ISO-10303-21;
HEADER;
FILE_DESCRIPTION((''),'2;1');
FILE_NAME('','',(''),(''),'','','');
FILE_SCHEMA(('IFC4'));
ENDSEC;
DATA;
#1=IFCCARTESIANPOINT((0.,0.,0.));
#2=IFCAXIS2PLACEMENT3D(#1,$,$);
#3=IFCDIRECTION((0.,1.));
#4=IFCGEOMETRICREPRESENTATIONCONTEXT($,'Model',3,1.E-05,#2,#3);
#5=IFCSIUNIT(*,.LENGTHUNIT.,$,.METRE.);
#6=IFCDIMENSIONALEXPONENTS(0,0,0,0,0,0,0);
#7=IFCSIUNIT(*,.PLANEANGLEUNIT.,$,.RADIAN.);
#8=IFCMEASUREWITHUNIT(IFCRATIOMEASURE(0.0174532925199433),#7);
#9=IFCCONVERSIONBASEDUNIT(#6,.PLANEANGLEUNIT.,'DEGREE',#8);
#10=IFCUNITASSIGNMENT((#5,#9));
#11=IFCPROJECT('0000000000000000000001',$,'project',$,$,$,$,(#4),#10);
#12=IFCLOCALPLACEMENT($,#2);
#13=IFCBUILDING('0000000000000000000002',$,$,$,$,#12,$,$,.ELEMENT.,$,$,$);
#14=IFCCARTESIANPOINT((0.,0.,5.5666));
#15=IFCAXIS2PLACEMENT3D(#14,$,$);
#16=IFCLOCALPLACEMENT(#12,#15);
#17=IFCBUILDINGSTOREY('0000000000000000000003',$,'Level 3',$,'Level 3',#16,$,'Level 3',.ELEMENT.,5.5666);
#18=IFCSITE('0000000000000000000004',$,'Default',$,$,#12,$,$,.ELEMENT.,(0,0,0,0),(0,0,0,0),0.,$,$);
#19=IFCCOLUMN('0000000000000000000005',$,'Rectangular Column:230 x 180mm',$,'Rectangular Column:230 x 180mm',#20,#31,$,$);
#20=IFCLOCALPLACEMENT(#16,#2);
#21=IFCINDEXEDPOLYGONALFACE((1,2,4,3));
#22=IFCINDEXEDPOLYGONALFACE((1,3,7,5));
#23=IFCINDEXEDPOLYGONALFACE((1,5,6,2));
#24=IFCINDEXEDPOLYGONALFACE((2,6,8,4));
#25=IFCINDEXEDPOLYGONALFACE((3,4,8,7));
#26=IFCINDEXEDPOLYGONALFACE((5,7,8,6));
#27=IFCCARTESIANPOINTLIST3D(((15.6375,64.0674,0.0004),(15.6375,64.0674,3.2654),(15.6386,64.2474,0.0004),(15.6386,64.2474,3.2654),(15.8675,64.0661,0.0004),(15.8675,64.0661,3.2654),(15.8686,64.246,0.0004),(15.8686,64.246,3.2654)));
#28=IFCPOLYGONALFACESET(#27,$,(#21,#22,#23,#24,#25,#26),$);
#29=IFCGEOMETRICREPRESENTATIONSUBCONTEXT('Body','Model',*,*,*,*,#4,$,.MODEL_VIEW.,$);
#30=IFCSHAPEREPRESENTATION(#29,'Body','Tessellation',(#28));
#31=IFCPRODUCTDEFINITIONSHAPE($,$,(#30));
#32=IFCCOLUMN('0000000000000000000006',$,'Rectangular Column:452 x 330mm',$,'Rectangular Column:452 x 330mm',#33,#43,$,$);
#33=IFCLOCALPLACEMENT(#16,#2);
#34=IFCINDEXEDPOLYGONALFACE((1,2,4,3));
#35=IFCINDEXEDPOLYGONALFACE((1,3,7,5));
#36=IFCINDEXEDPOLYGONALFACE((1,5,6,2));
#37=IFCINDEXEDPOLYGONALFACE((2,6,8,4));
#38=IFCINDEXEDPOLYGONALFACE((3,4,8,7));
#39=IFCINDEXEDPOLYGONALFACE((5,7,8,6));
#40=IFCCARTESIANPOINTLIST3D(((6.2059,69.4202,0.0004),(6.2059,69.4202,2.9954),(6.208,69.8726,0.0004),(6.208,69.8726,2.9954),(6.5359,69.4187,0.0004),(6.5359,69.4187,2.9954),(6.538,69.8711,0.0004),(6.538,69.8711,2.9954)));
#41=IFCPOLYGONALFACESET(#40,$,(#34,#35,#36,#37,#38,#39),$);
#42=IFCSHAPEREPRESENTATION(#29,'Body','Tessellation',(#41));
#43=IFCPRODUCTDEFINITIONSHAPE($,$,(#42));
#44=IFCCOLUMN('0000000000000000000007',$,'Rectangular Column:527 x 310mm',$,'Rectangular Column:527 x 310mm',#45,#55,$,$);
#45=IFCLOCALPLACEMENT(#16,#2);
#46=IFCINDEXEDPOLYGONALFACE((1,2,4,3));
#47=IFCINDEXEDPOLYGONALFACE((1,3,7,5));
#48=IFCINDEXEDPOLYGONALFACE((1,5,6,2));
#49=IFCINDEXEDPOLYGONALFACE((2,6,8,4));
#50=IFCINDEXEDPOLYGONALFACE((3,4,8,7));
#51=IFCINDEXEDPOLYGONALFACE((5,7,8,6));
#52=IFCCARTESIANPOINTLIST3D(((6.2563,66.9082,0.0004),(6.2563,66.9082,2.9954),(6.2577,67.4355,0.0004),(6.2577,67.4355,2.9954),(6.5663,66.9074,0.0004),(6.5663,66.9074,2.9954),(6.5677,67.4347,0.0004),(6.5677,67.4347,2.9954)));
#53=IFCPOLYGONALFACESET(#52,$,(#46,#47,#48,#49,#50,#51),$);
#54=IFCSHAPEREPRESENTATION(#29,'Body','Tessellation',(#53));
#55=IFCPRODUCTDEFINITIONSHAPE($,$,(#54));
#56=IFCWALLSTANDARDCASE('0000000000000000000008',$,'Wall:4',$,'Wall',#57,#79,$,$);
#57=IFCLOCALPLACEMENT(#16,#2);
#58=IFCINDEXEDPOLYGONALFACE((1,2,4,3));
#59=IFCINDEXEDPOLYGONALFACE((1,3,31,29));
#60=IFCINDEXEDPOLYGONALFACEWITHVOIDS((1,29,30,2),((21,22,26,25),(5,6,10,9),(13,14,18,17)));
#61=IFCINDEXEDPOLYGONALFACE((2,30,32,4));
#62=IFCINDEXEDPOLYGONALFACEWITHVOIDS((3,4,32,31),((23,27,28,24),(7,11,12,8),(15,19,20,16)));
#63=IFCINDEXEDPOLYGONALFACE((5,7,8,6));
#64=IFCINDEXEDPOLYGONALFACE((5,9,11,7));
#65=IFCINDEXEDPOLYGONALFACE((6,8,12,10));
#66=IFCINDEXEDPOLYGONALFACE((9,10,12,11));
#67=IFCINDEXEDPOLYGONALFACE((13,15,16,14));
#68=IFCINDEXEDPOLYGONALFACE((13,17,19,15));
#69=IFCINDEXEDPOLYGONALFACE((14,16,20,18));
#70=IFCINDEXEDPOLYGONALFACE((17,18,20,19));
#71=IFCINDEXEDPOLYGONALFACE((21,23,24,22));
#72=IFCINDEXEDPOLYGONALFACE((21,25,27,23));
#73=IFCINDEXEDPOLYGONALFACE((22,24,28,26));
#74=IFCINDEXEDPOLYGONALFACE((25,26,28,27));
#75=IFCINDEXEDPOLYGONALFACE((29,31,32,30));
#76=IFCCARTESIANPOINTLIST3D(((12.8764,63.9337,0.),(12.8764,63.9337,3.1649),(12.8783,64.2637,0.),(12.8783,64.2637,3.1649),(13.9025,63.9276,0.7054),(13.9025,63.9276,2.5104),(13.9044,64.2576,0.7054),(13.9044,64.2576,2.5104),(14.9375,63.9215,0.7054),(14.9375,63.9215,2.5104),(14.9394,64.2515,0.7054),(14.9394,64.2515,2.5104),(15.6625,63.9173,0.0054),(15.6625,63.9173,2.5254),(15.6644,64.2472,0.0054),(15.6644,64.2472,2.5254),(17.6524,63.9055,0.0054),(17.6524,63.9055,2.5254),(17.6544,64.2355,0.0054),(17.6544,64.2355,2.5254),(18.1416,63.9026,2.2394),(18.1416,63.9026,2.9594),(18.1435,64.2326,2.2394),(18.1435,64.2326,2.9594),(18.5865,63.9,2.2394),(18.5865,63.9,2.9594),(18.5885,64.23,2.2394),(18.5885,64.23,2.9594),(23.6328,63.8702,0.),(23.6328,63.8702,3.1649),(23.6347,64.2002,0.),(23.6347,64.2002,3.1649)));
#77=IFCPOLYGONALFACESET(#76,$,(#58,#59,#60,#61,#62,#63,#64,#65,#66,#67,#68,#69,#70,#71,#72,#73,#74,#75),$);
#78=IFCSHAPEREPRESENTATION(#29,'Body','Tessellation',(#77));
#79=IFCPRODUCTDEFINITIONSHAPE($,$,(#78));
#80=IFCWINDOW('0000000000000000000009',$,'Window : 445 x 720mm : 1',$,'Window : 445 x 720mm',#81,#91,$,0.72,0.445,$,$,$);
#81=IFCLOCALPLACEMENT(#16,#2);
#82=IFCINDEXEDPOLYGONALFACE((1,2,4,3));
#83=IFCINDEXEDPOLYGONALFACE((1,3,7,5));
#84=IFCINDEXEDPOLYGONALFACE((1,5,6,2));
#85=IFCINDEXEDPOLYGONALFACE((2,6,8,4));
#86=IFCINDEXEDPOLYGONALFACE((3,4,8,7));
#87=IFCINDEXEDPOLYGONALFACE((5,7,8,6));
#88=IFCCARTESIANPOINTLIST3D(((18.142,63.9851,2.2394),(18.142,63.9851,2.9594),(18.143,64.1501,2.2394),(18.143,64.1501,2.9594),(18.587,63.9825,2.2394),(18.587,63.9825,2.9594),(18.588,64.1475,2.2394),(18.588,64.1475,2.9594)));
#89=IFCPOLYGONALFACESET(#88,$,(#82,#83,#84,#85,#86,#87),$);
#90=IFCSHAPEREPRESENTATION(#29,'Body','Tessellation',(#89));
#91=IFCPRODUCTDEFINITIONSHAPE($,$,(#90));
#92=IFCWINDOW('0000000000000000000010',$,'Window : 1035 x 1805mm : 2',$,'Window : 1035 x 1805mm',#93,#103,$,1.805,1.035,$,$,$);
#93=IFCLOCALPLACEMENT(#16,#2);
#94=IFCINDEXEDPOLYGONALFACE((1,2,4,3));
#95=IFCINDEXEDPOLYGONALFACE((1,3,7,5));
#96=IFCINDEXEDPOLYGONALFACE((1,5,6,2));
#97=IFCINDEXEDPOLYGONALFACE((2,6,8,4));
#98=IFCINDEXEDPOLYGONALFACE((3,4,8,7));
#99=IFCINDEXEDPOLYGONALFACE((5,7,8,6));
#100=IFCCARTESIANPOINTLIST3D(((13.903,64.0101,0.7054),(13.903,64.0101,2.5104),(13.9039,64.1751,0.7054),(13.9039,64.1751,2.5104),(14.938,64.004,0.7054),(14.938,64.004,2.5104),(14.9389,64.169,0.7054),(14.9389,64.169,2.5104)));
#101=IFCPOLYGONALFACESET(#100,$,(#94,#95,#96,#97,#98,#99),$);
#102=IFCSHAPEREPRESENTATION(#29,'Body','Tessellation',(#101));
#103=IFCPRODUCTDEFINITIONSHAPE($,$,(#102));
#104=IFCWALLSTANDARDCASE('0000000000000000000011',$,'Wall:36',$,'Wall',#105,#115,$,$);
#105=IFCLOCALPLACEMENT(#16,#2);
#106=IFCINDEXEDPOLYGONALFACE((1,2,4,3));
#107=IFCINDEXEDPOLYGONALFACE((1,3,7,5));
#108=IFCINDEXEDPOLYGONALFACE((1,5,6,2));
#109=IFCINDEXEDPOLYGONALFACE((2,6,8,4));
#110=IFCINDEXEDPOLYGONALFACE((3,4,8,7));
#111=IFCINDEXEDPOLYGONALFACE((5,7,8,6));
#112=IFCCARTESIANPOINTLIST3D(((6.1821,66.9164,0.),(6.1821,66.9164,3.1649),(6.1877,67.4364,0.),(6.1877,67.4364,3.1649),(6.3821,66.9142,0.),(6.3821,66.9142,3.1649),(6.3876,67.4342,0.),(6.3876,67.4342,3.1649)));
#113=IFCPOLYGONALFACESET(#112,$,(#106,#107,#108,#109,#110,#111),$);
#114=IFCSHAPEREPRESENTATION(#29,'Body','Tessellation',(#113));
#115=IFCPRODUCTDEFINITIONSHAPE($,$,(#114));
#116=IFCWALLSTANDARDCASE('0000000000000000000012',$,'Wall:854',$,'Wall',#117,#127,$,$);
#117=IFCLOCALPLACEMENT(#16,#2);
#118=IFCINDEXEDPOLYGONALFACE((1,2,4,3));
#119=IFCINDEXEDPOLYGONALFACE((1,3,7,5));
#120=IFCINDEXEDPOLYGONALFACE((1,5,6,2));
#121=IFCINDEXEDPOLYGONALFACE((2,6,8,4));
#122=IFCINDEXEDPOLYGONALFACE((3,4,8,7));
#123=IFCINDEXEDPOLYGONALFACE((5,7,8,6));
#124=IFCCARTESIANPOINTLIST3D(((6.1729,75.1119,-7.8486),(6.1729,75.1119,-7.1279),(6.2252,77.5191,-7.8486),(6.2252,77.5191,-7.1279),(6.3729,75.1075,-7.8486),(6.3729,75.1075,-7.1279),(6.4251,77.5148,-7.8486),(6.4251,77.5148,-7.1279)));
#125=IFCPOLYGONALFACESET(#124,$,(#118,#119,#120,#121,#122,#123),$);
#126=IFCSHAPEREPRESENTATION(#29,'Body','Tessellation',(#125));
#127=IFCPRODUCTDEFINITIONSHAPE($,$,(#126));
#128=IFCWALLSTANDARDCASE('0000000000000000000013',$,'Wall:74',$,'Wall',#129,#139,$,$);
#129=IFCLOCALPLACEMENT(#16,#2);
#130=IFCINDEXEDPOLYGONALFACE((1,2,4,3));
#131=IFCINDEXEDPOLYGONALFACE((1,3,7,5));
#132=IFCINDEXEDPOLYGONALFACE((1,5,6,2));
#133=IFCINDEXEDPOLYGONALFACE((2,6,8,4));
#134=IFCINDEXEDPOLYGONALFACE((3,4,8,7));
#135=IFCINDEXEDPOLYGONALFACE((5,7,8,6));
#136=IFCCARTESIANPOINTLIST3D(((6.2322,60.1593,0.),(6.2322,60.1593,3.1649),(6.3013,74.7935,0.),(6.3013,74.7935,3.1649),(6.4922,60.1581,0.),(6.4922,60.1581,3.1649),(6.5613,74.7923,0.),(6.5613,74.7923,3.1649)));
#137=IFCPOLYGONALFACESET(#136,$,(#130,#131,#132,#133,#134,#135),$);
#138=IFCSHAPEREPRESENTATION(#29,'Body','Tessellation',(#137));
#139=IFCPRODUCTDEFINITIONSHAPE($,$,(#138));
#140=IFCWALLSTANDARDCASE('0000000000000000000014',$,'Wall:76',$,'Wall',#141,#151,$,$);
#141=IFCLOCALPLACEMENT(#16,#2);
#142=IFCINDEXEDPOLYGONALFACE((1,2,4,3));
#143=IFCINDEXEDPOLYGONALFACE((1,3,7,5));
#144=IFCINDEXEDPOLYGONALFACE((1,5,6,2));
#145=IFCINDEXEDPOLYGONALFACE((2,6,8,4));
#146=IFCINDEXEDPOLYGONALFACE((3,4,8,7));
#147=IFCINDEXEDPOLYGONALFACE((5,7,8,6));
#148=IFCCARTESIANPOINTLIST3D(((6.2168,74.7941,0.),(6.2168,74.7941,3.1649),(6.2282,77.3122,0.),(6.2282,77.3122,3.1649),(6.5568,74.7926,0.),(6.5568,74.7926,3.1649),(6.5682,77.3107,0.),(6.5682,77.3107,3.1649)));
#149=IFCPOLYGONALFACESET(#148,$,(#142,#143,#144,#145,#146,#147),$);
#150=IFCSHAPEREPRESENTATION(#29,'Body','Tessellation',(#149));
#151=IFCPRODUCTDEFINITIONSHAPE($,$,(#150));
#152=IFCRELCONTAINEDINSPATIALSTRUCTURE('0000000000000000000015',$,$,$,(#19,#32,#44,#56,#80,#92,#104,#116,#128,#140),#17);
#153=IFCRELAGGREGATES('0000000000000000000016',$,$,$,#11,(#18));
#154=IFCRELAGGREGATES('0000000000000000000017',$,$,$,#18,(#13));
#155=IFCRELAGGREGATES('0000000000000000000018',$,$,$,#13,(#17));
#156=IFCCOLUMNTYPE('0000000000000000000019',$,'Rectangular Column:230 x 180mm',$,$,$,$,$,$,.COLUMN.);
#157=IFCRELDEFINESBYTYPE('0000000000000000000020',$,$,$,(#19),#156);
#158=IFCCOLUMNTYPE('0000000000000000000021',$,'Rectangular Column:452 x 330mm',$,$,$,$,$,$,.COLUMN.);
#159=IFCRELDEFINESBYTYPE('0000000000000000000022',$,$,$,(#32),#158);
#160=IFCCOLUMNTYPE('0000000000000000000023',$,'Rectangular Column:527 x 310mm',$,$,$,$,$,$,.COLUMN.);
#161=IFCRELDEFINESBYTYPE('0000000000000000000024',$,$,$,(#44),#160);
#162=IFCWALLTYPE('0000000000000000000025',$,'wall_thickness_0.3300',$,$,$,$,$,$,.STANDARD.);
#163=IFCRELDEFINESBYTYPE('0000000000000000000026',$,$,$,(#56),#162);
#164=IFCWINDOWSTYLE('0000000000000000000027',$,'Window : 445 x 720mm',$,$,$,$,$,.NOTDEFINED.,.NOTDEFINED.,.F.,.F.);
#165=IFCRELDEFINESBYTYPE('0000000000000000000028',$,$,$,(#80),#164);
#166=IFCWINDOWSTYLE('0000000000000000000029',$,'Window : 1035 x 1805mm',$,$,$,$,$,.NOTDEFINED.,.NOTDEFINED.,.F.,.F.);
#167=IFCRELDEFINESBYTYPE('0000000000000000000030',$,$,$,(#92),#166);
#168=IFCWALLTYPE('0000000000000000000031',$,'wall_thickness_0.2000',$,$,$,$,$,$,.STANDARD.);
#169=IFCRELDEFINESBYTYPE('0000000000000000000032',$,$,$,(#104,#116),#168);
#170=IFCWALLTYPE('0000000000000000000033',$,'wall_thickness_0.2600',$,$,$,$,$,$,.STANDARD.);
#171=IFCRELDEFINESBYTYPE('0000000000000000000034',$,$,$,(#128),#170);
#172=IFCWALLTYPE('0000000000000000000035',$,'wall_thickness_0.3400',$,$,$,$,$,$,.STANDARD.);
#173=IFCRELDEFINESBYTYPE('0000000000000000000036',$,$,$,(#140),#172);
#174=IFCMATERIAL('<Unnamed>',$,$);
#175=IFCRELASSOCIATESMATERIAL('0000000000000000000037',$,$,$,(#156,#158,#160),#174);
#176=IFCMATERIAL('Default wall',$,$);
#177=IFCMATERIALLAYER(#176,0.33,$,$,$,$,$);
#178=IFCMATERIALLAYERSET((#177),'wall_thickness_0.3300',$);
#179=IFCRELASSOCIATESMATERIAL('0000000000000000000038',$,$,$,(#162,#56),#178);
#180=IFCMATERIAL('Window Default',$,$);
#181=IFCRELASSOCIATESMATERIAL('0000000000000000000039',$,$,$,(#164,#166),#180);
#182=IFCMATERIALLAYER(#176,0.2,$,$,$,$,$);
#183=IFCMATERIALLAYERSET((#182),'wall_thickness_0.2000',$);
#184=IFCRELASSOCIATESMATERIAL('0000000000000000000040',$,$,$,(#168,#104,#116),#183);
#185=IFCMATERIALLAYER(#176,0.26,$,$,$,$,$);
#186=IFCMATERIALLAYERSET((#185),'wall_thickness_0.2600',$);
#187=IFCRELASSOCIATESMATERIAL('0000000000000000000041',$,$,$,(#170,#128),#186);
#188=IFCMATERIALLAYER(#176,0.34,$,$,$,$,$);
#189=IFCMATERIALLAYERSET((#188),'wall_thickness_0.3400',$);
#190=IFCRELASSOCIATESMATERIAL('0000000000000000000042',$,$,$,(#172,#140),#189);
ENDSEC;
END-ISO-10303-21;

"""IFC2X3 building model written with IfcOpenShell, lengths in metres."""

from ifc_helpers import new_model, entity, si_unit, converted_unit, direction, frame, frame_2d, origin, origin_2d_with_axis, place, context, subcontext, project, spatial, polyline, rectangle, outline, extrude, source, transform, mapped, material, layer, layer_set, layer_usage, type_object, type_shapes, element, fill, save


model = new_model("IFC2X3")

# Units and contexts
model_context = context("Model", 3, precision=1e-05, world=origin(), true_north=direction((0.0, 1.0)))
body_context = subcontext(model_context, "Body", "Model", "MODEL_VIEW")
ifc_project = project(units=[si_unit("LENGTHUNIT", "METRE"), converted_unit("PLANEANGLEUNIT", "DEGREE", entity("IfcRatioMeasure", 0.0174532925199433), si_unit("PLANEANGLEUNIT", "RADIAN"), dimensions=[0, 0, 0, 0, 0, 0, 0])], contexts=[model_context])

# Site, building, storey
placement_1 = place(None, origin())
site = spatial("IfcSite", under=ifc_project, at=placement_1, Name="Default", CompositionType="ELEMENT", RefLatitude=(0, 0, 0, 0), RefLongitude=(0, 0, 0, 0), RefElevation=0.0)
building = spatial("IfcBuilding", under=site, at=placement_1, CompositionType="ELEMENT")
storey_placement = place(placement_1, frame((0.0, 0.0, 5.5666)))
storey = spatial("IfcBuildingStorey", under=building, at=storey_placement, Name="Level 3", ObjectType="Level 3", LongName="Level 3", CompositionType="ELEMENT", Elevation=5.5666)

# Columns
ifc_material_1 = material(Name="<Unnamed>")
column_type_1 = type_object("IfcColumnType", Name="Rectangular Column:230 x 180mm", PredefinedType="COLUMN", material=ifc_material_1)
shared_shape_1 = source(origin(), body_context, "Body", "SweptSolid", [
    extrude(rectangle(XDim=0.23, YDim=0.18, at=origin_2d_with_axis()), frame((0.0, 0.0, 0.0), z_axis=(0.0, 0.0, 1.0), x_axis=(0.0, -1.0, 0.0)), (0.0, 0.0, 1.0), 3.265),
])
type_shapes(column_type_1, [shared_shape_1])
column_1_placement = place(placement_1, frame((15.753, 64.1567, 5.567), z_axis=(0.0, 0.0, 1.0), x_axis=(0.005897, 0.999983, 0.0)))
element("IfcColumn", 1, at=column_1_placement, inside=storey, type_object=column_type_1, Name="Rectangular Column:230 x 180mm", ObjectType="Rectangular Column:230 x 180mm", context=body_context, shape_type="MappedRepresentation", body=[
    mapped(shared_shape_1, transform((0.0, 0.0, 0.0), scale=1.0)),
])
column_type_2 = type_object("IfcColumnType", Name="Rectangular Column:452 x 330mm", PredefinedType="COLUMN", material=ifc_material_1)
shared_shape_2 = source(origin(), body_context, "Body", "SweptSolid", [
    extrude(rectangle(XDim=0.4524, YDim=0.33, at=origin_2d_with_axis()), frame((0.0, 0.0, 0.0), z_axis=(0.0, 0.0, 1.0), x_axis=(0.0, -1.0, 0.0)), (0.0, 0.0, 1.0), 2.995),
])
type_shapes(column_type_2, [shared_shape_2])
column_2_placement = place(placement_1, frame((6.372, 69.6456, 5.567), z_axis=(0.0, 0.0, 1.0), x_axis=(0.999989, -0.004723, 0.0)))
element("IfcColumn", 2, at=column_2_placement, inside=storey, type_object=column_type_2, Name="Rectangular Column:452 x 330mm", ObjectType="Rectangular Column:452 x 330mm", context=body_context, shape_type="MappedRepresentation", body=[
    mapped(shared_shape_2, transform((0.0, 0.0, 0.0), scale=1.0)),
])
column_type_3 = type_object("IfcColumnType", Name="Rectangular Column:527 x 310mm", PredefinedType="COLUMN", material=ifc_material_1)
shared_shape_3 = source(origin(), body_context, "Body", "SweptSolid", [
    extrude(rectangle(XDim=0.5273, YDim=0.31, at=origin_2d_with_axis()), frame((0.0, 0.0, 0.0), z_axis=(0.0, 0.0, 1.0), x_axis=(0.0, -1.0, 0.0)), (0.0, 0.0, 1.0), 2.995),
])
type_shapes(column_type_3, [shared_shape_3])
column_3_placement = place(placement_1, frame((6.412, 67.1714, 5.567), z_axis=(0.0, 0.0, 1.0), x_axis=(-0.999997, 0.002601, 0.0)))
element("IfcColumn", 3, at=column_3_placement, inside=storey, type_object=column_type_3, Name="Rectangular Column:527 x 310mm", ObjectType="Rectangular Column:527 x 310mm", context=body_context, shape_type="MappedRepresentation", body=[
    mapped(shared_shape_3, transform((0.0, 0.0, 0.0), scale=1.0)),
])

# Wall, openings, windows
ifc_material_2 = material(Name="Default wall")
ifc_layer_1 = layer(ifc_material_2, 0.33)
ifc_layer_set_1 = layer_set([ifc_layer_1], Name="wall_thickness_0.3300")
ifc_layer_usage_1 = layer_usage(ifc_layer_set_1, "AXIS2", "POSITIVE", -0.165)
wall_type_1 = type_object("IfcWallType", Name="wall_thickness_0.3300", PredefinedType="STANDARD", material=ifc_layer_set_1)
wall_1_placement = place(storey_placement, frame((12.8774, 64.0987, 0.0), z_axis=(0.0, 0.0, 1.0), x_axis=(0.999983, -0.005904, 0.0)))
wall_1 = element("IfcWallStandardCase", 4, at=wall_1_placement, inside=storey, type_object=wall_type_1, material=ifc_layer_usage_1, Name="Wall:4", ObjectType="Wall", context=body_context, shape_type="SweptSolid", body=[
    extrude(outline(polyline([(10.7565, -0.165), (10.7565, 0.165), (0.0, 0.165), (0.0, -0.165), (10.7565, -0.165)])), origin(), (0.0, 0.0, 1.0), 3.1649),
])
opening_1_placement = place(wall_1_placement, frame((2.7861, -0.165, 0.0054)))
element("IfcOpeningElement", 5, at=opening_1_placement, cuts=wall_1, ObjectType="Opening", context=body_context, shape_type="SweptSolid", body=[
    extrude(rectangle(XDim=1.99, YDim=2.52, at=frame_2d((1.26, 0.995), x_axis=(0.0, 1.0))), frame((0.0, 0.0, 0.0), z_axis=(0.0, 1.0, 0.0), x_axis=(0.0, 0.0, 1.0)), (0.0, 0.0, 1.0), 0.33),
])
opening_2_placement = place(wall_1_placement, frame((5.2652, -0.165, 2.2394)))
opening_2 = element("IfcOpeningElement", 6, at=opening_2_placement, cuts=wall_1, ObjectType="Opening", context=body_context, shape_type="SweptSolid", body=[
    extrude(rectangle(XDim=0.445, YDim=0.72, at=frame_2d((0.36, 0.2225), x_axis=(0.0, 1.0))), frame((0.0, 0.0, 0.0), z_axis=(0.0, 1.0, 0.0), x_axis=(0.0, 0.0, 1.0)), (0.0, 0.0, 1.0), 0.33),
])
opening_3_placement = place(wall_1_placement, frame((1.0261, -0.165, 0.7054)))
opening_3 = element("IfcOpeningElement", 7, at=opening_3_placement, cuts=wall_1, ObjectType="Opening", context=body_context, shape_type="SweptSolid", body=[
    extrude(rectangle(XDim=1.035, YDim=1.805, at=frame_2d((0.9025, 0.5175), x_axis=(0.0, 1.0))), frame((0.0, 0.0, 0.0), z_axis=(0.0, 1.0, 0.0), x_axis=(0.0, 0.0, 1.0)), (0.0, 0.0, 1.0), 0.33),
])
ifc_material_3 = material(Name="Window Default")
window_style_1 = type_object("IfcWindowStyle", Name="Window : 445 x 720mm", ConstructionType="NOTDEFINED", OperationType="NOTDEFINED", ParameterTakesPrecedence=False, Sizeable=False, material=ifc_material_3)
shared_shape_4 = source(origin(), body_context, "Body", "SweptSolid", [
    extrude(rectangle(XDim=0.165, YDim=0.445, at=origin_2d_with_axis()), frame((0.2225, 0.165, 0.0), z_axis=(0.0, 0.0, 1.0), x_axis=(0.0, 1.0, 0.0)), (0.0, 0.0, 1.0), 0.72),
])
type_shapes(window_style_1, [shared_shape_4])
window_1_placement = place(opening_2_placement, origin())
window_1 = element("IfcWindow", 8, at=window_1_placement, inside=storey, type_object=window_style_1, Name="Window : 445 x 720mm : 1", ObjectType="Window : 445 x 720mm", OverallHeight=0.72, OverallWidth=0.445, context=body_context, shape_type="MappedRepresentation", body=[
    mapped(shared_shape_4, transform((0.0, 0.0, 0.0), scale=1.0)),
])
fill(opening_2, window_1)
window_style_2 = type_object("IfcWindowStyle", Name="Window : 1035 x 1805mm", ConstructionType="NOTDEFINED", OperationType="NOTDEFINED", ParameterTakesPrecedence=False, Sizeable=False, material=ifc_material_3)
shared_shape_5 = source(origin(), body_context, "Body", "SweptSolid", [
    extrude(rectangle(XDim=0.165, YDim=1.035, at=origin_2d_with_axis()), frame((0.5175, 0.165, 0.0), z_axis=(0.0, 0.0, 1.0), x_axis=(0.0, 1.0, 0.0)), (0.0, 0.0, 1.0), 1.805),
])
type_shapes(window_style_2, [shared_shape_5])
window_2_placement = place(opening_3_placement, origin())
window_2 = element("IfcWindow", 9, at=window_2_placement, inside=storey, type_object=window_style_2, Name="Window : 1035 x 1805mm : 2", ObjectType="Window : 1035 x 1805mm", OverallHeight=1.805, OverallWidth=1.035, context=body_context, shape_type="MappedRepresentation", body=[
    mapped(shared_shape_5, transform((0.0, 0.0, 0.0), scale=1.0)),
])
fill(opening_3, window_2)

# Walls
ifc_layer_2 = layer(ifc_material_2, 0.2)
ifc_layer_set_2 = layer_set([ifc_layer_2], Name="wall_thickness_0.2000")
ifc_layer_usage_2 = layer_usage(ifc_layer_set_2, "AXIS2", "POSITIVE", -0.1)
wall_type_2 = type_object("IfcWallType", Name="wall_thickness_0.2000", PredefinedType="STANDARD", material=ifc_layer_set_2)
wall_2_placement = place(storey_placement, frame((6.2876, 67.4353, 0.0), z_axis=(0.0, 0.0, 1.0), x_axis=(-0.010716, -0.999943, 0.0)))
element("IfcWallStandardCase", 10, at=wall_2_placement, inside=storey, type_object=wall_type_2, material=ifc_layer_usage_2, Name="Wall:36", ObjectType="Wall", context=body_context, shape_type="SweptSolid", body=[
    extrude(outline(polyline([(0.52, -0.1), (0.52, 0.1), (0.0, 0.1), (0.0, -0.1), (0.52, -0.1)])), origin(), (0.0, 0.0, 1.0), 3.1649),
])
placement_2 = place(placement_1, frame((0.0, 0.0, -2.282)))
wall_3_placement = place(placement_2, frame((6.3251, 77.5169, 0.0), z_axis=(0.0, 0.0, 1.0), x_axis=(-0.021695, -0.999765, 0.0)))
element("IfcWallStandardCase", 11, at=wall_3_placement, inside=storey, type_object=wall_type_2, material=ifc_layer_usage_2, Name="Wall:854", ObjectType="Wall", context=body_context, shape_type="SweptSolid", body=[
    extrude(outline(polyline([(2.4078, -0.1), (2.4078, 0.1), (0.0, 0.1), (0.0, -0.1), (2.4078, -0.1)])), origin(), (0.0, 0.0, 1.0), 0.7207),
])
ifc_layer_3 = layer(ifc_material_2, 0.26)
ifc_layer_set_3 = layer_set([ifc_layer_3], Name="wall_thickness_0.2600")
ifc_layer_usage_3 = layer_usage(ifc_layer_set_3, "AXIS2", "POSITIVE", -0.13)
wall_type_3 = type_object("IfcWallType", Name="wall_thickness_0.2600", PredefinedType="STANDARD", material=ifc_layer_set_3)
wall_4_placement = place(storey_placement, frame((6.4313, 74.7929, 0.0), z_axis=(0.0, 0.0, 1.0), x_axis=(-0.004723, -0.999989, 0.0)))
element("IfcWallStandardCase", 12, at=wall_4_placement, inside=storey, type_object=wall_type_3, material=ifc_layer_usage_3, Name="Wall:74", ObjectType="Wall", context=body_context, shape_type="SweptSolid", body=[
    extrude(outline(polyline([(14.6343, -0.13), (14.6343, 0.13), (0.0, 0.13), (0.0, -0.13), (14.6343, -0.13)])), origin(), (0.0, 0.0, 1.0), 3.1649),
])
ifc_layer_4 = layer(ifc_material_2, 0.34)
ifc_layer_set_4 = layer_set([ifc_layer_4], Name="wall_thickness_0.3400")
ifc_layer_usage_4 = layer_usage(ifc_layer_set_4, "AXIS2", "POSITIVE", -0.17)
wall_type_4 = type_object("IfcWallType", Name="wall_thickness_0.3400", PredefinedType="STANDARD", material=ifc_layer_set_4)
wall_5_placement = place(storey_placement, frame((6.3982, 77.3114, 0.0), z_axis=(0.0, 0.0, 1.0), x_axis=(-0.004561, -0.99999, 0.0)))
element("IfcWallStandardCase", 13, at=wall_5_placement, inside=storey, type_object=wall_type_4, material=ifc_layer_usage_4, Name="Wall:76", ObjectType="Wall", context=body_context, shape_type="SweptSolid", body=[
    extrude(outline(polyline([(2.5181, -0.17), (2.5181, 0.17), (0.0, 0.17), (0.0, -0.17), (2.5181, -0.17)])), origin(), (0.0, 0.0, 1.0), 3.1649),
])

save(model, "model.ifc")
